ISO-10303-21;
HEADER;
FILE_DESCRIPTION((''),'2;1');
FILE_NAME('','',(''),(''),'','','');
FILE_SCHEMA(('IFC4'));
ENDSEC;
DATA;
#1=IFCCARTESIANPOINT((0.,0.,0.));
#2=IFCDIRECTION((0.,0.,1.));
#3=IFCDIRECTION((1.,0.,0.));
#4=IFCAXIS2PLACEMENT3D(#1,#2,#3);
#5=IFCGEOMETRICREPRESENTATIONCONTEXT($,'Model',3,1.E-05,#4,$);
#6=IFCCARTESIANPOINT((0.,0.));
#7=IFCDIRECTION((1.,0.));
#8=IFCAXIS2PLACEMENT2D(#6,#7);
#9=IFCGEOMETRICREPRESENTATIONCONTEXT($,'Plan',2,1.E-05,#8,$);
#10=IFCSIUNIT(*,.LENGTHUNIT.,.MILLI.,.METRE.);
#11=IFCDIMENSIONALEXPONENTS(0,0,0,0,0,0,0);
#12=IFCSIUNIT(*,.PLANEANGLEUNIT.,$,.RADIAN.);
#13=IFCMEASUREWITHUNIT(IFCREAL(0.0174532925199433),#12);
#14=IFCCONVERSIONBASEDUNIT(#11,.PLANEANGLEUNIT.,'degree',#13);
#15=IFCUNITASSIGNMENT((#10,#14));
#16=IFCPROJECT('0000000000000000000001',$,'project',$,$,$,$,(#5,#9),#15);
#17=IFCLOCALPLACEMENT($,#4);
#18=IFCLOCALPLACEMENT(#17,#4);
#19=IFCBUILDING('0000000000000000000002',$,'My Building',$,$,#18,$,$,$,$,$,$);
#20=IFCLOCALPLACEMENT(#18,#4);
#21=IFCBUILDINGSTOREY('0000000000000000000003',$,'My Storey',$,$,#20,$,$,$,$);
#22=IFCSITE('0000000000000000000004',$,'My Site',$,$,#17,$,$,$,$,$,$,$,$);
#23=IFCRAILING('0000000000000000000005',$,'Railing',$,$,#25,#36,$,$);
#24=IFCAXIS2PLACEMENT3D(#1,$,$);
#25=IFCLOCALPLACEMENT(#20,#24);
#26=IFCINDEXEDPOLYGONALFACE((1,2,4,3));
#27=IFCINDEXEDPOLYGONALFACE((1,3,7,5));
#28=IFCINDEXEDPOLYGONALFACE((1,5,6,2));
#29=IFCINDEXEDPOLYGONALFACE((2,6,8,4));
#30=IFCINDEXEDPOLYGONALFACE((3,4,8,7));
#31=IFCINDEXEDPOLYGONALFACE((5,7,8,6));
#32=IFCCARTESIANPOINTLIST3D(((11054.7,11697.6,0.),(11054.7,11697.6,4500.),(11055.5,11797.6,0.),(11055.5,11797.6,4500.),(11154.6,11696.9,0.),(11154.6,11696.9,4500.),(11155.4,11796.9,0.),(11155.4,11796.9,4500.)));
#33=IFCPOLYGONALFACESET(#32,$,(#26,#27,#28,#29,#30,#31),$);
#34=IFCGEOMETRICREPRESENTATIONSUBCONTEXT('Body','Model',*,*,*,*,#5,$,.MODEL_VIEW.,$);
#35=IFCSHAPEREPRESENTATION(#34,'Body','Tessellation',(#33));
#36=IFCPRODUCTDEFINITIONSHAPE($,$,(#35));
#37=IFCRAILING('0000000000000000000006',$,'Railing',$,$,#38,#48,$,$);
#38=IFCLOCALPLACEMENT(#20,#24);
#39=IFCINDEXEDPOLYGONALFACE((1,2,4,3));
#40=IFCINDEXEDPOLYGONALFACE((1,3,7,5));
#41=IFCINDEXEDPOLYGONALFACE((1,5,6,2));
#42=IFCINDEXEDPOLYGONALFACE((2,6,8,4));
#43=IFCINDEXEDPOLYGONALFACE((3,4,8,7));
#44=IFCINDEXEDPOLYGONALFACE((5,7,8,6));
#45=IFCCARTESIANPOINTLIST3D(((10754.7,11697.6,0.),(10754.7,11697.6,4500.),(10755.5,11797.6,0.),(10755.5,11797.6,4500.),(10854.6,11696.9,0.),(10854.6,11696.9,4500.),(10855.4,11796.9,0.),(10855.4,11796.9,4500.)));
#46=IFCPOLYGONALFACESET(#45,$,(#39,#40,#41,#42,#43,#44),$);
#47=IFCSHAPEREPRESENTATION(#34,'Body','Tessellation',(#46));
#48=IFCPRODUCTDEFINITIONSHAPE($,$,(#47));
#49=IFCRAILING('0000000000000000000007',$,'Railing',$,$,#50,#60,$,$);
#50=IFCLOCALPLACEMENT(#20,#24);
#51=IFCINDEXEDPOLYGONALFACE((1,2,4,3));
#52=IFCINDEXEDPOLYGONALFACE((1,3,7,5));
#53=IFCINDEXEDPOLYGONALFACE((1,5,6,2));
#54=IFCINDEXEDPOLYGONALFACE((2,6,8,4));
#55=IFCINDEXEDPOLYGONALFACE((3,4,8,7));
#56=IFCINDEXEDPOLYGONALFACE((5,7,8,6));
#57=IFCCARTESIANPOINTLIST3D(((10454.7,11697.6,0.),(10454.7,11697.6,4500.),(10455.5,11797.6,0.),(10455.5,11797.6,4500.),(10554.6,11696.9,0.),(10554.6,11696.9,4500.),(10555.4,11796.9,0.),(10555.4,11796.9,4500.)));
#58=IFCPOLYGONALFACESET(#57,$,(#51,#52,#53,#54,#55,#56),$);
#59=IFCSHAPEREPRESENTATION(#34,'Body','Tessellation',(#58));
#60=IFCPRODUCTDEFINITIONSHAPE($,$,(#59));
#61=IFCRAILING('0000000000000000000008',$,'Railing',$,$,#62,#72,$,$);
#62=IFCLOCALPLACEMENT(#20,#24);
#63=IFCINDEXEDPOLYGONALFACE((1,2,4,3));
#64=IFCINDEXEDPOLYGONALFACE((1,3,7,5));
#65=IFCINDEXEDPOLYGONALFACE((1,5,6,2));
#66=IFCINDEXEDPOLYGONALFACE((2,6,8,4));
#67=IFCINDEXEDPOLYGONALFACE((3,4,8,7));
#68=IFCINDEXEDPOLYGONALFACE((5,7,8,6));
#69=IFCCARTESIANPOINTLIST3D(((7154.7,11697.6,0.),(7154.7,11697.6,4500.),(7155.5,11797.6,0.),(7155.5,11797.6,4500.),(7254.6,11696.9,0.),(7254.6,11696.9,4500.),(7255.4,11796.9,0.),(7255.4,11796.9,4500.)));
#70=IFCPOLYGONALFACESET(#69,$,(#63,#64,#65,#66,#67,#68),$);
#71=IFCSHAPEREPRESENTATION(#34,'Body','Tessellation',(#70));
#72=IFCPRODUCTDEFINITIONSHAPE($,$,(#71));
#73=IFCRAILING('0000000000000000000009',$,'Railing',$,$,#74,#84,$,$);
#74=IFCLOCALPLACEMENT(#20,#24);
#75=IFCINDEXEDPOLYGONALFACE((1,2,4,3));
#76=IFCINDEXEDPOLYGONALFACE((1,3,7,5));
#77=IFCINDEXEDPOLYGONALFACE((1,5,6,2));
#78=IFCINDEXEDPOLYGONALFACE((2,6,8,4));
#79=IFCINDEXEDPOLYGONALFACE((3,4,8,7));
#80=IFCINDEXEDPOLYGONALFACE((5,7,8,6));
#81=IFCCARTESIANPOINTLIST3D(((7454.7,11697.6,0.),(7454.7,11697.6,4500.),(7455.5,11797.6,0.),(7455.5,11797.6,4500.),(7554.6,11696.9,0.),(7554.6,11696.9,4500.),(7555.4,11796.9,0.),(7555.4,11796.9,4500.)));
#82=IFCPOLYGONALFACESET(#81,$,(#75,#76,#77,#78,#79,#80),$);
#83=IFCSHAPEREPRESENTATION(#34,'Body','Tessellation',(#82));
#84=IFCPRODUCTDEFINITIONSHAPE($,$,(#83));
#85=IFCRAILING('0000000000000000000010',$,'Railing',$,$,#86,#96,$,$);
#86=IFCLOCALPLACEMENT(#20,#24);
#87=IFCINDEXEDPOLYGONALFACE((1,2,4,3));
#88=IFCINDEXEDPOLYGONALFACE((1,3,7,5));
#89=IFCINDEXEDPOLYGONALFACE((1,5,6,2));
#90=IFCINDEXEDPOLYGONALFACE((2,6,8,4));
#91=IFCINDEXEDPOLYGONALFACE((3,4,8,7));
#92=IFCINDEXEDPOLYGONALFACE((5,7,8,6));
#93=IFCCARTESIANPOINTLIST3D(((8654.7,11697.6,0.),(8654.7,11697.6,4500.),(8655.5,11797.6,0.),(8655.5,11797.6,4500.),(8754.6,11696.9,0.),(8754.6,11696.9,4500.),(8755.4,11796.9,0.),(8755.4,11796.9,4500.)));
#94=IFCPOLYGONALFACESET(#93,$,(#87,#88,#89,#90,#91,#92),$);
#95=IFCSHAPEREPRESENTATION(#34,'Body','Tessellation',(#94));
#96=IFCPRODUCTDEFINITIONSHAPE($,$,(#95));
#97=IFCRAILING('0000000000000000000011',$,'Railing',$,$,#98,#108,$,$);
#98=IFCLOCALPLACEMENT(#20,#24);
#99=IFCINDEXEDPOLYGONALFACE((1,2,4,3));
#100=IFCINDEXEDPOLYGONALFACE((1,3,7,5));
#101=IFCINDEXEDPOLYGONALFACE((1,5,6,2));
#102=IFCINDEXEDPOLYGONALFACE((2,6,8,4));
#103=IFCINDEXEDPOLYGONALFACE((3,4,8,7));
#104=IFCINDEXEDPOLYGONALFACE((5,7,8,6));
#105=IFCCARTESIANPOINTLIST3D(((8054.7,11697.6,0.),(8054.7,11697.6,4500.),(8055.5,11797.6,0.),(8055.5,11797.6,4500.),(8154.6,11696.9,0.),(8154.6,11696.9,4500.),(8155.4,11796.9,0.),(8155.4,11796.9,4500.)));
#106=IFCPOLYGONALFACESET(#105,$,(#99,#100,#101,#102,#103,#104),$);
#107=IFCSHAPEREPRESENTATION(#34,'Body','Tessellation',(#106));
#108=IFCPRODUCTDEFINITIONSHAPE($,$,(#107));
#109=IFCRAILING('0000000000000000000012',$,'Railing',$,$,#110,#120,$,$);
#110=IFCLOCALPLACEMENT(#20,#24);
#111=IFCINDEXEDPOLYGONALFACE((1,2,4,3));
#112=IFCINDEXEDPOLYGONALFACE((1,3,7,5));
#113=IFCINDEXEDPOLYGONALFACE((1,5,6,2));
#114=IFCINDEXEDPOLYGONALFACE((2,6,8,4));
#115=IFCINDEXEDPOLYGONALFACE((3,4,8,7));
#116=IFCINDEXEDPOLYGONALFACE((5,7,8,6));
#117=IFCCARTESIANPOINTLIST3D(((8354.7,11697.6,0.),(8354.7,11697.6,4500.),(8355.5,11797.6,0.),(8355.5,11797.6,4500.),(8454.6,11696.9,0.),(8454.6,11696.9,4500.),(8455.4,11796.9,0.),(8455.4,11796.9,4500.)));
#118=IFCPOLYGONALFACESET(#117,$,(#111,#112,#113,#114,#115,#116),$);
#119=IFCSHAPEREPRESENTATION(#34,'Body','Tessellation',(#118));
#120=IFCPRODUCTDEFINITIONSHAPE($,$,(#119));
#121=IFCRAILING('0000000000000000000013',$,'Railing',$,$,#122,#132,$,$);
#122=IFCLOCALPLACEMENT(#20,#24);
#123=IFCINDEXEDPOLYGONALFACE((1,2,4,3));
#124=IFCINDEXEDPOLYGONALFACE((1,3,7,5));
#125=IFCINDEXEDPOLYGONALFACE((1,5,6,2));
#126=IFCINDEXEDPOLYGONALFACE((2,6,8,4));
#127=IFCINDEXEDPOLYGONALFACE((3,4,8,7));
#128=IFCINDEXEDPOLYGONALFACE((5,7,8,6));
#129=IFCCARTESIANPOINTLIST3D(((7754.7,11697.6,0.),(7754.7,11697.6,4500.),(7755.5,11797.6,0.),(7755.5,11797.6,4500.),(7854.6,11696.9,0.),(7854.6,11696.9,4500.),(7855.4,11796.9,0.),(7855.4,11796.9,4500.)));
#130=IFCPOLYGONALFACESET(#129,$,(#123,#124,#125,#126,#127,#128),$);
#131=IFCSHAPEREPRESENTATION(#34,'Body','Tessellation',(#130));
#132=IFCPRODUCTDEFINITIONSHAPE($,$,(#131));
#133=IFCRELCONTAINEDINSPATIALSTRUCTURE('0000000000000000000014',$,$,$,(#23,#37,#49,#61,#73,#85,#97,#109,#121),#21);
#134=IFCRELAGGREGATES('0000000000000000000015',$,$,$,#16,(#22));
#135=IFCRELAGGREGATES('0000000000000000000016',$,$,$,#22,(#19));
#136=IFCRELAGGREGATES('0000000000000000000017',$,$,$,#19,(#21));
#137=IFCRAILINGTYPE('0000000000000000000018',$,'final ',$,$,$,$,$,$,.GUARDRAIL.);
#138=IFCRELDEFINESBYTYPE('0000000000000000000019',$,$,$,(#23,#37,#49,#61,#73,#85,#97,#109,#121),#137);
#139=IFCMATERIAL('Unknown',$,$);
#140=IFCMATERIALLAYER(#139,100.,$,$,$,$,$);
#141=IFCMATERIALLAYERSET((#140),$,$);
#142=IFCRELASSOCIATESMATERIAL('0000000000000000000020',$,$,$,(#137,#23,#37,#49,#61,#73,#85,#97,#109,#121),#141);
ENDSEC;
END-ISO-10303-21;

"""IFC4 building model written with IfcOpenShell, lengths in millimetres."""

from ifc_helpers import new_model, entity, si_unit, converted_unit, frame, origin_with_axes, origin_2d_with_axis, place, context, subcontext, project, spatial, line, indexed_curve, outline, extrude, material, layer, layer_set, layer_usage, type_object, element, save


model = new_model("IFC4")

# Units and contexts
model_context = context("Model", 3, precision=1e-05, world=origin_with_axes())
plan_context = context("Plan", 2, precision=1e-05, world=origin_2d_with_axis())
body_context = subcontext(model_context, "Body", "Model", "MODEL_VIEW")
ifc_project = project(units=[si_unit("LENGTHUNIT", "METRE", prefix="MILLI"), converted_unit("PLANEANGLEUNIT", "degree", entity("IfcReal", 0.0174532925199433), si_unit("PLANEANGLEUNIT", "RADIAN"), dimensions=[0, 0, 0, 0, 0, 0, 0])], contexts=[model_context, plan_context])

# Site, building, storey
site_placement = place(None, origin_with_axes())
site = spatial("IfcSite", under=ifc_project, at=site_placement, Name="My Site")
building_placement = place(site_placement, origin_with_axes())
building = spatial("IfcBuilding", under=site, at=building_placement, Name="My Building")
storey_placement = place(building_placement, origin_with_axes())
storey = spatial("IfcBuildingStorey", under=building, at=storey_placement, Name="My Storey")

# Shared definitions
ifc_material = material(Name="Unknown")

# Railings
ifc_layer_1 = layer(ifc_material, 100.0)
ifc_layer_set_1 = layer_set([ifc_layer_1])
railing_type = type_object("IfcRailingType", Name="final ", PredefinedType="GUARDRAIL", material=ifc_layer_set_1)
ifc_layer_usage_1 = layer_usage(ifc_layer_set_1, "AXIS2", "POSITIVE", 0.0)
railing_1_placement = place(storey_placement, frame((11155.4, 11796.9, 0.0), z_axis=(0.0, 0.0, 1.0), x_axis=(-0.99997, 0.007689, 0.0)))
element("IfcRailing", 1, at=railing_1_placement, inside=storey, type_object=railing_type, material=ifc_layer_usage_1, Name="Railing", context=body_context, shape_type="SweptSolid", body=[
    extrude(outline(indexed_curve([(0.0, 0.0), (0.0, 100.0), (99.8, 100.0), (99.8, 0.0)], segments=[line(1, 2, 3, 4, 1)])), origin_with_axes(), (0.0, 0.0, 1.0), 4500.0),
])
ifc_layer_usage_2 = layer_usage(ifc_layer_set_1, "AXIS2", "POSITIVE", 0.0)
railing_2_placement = place(storey_placement, frame((10855.4, 11796.9, 0.0), z_axis=(0.0, 0.0, 1.0), x_axis=(-0.99997, 0.007689, 0.0)))
element("IfcRailing", 2, at=railing_2_placement, inside=storey, type_object=railing_type, material=ifc_layer_usage_2, Name="Railing", context=body_context, shape_type="SweptSolid", body=[
    extrude(outline(indexed_curve([(0.0, 0.0), (0.0, 100.0), (99.8, 100.0), (99.8, 0.0)], segments=[line(1, 2, 3, 4, 1)])), origin_with_axes(), (0.0, 0.0, 1.0), 4500.0),
])
ifc_layer_usage_3 = layer_usage(ifc_layer_set_1, "AXIS2", "POSITIVE", 0.0)
railing_3_placement = place(storey_placement, frame((10555.4, 11796.9, 0.0), z_axis=(0.0, 0.0, 1.0), x_axis=(-0.99997, 0.007689, 0.0)))
element("IfcRailing", 3, at=railing_3_placement, inside=storey, type_object=railing_type, material=ifc_layer_usage_3, Name="Railing", context=body_context, shape_type="SweptSolid", body=[
    extrude(outline(indexed_curve([(0.0, 0.0), (0.0, 100.0), (99.8, 100.0), (99.8, 0.0)], segments=[line(1, 2, 3, 4, 1)])), origin_with_axes(), (0.0, 0.0, 1.0), 4500.0),
])
ifc_layer_usage_4 = layer_usage(ifc_layer_set_1, "AXIS2", "POSITIVE", 0.0)
railing_4_placement = place(storey_placement, frame((7255.4, 11796.9, 0.0), z_axis=(0.0, 0.0, 1.0), x_axis=(-0.99997, 0.007689, 0.0)))
element("IfcRailing", 4, at=railing_4_placement, inside=storey, type_object=railing_type, material=ifc_layer_usage_4, Name="Railing", context=body_context, shape_type="SweptSolid", body=[
    extrude(outline(indexed_curve([(0.0, 0.0), (0.0, 100.0), (99.8, 100.0), (99.8, 0.0)], segments=[line(1, 2, 3, 4, 1)])), origin_with_axes(), (0.0, 0.0, 1.0), 4500.0),
])
ifc_layer_usage_5 = layer_usage(ifc_layer_set_1, "AXIS2", "POSITIVE", 0.0)
railing_5_placement = place(storey_placement, frame((7555.4, 11796.9, 0.0), z_axis=(0.0, 0.0, 1.0), x_axis=(-0.99997, 0.007689, 0.0)))
element("IfcRailing", 5, at=railing_5_placement, inside=storey, type_object=railing_type, material=ifc_layer_usage_5, Name="Railing", context=body_context, shape_type="SweptSolid", body=[
    extrude(outline(indexed_curve([(0.0, 0.0), (0.0, 100.0), (99.8, 100.0), (99.8, 0.0)], segments=[line(1, 2, 3, 4, 1)])), origin_with_axes(), (0.0, 0.0, 1.0), 4500.0),
])
ifc_layer_usage_6 = layer_usage(ifc_layer_set_1, "AXIS2", "POSITIVE", 0.0)
railing_6_placement = place(storey_placement, frame((8755.4, 11796.9, 0.0), z_axis=(0.0, 0.0, 1.0), x_axis=(-0.99997, 0.007689, 0.0)))
element("IfcRailing", 6, at=railing_6_placement, inside=storey, type_object=railing_type, material=ifc_layer_usage_6, Name="Railing", context=body_context, shape_type="SweptSolid", body=[
    extrude(outline(indexed_curve([(0.0, 0.0), (0.0, 100.0), (99.8, 100.0), (99.8, 0.0)], segments=[line(1, 2, 3, 4, 1)])), origin_with_axes(), (0.0, 0.0, 1.0), 4500.0),
])
ifc_layer_usage_7 = layer_usage(ifc_layer_set_1, "AXIS2", "POSITIVE", 0.0)
railing_7_placement = place(storey_placement, frame((8155.4, 11796.9, 0.0), z_axis=(0.0, 0.0, 1.0), x_axis=(-0.99997, 0.007689, 0.0)))
element("IfcRailing", 7, at=railing_7_placement, inside=storey, type_object=railing_type, material=ifc_layer_usage_7, Name="Railing", context=body_context, shape_type="SweptSolid", body=[
    extrude(outline(indexed_curve([(0.0, 0.0), (0.0, 100.0), (99.8, 100.0), (99.8, 0.0)], segments=[line(1, 2, 3, 4, 1)])), origin_with_axes(), (0.0, 0.0, 1.0), 4500.0),
])
ifc_layer_usage_8 = layer_usage(ifc_layer_set_1, "AXIS2", "POSITIVE", 0.0)
railing_8_placement = place(storey_placement, frame((8455.4, 11796.9, 0.0), z_axis=(0.0, 0.0, 1.0), x_axis=(-0.99997, 0.007689, 0.0)))
element("IfcRailing", 8, at=railing_8_placement, inside=storey, type_object=railing_type, material=ifc_layer_usage_8, Name="Railing", context=body_context, shape_type="SweptSolid", body=[
    extrude(outline(indexed_curve([(0.0, 0.0), (0.0, 100.0), (99.8, 100.0), (99.8, 0.0)], segments=[line(1, 2, 3, 4, 1)])), origin_with_axes(), (0.0, 0.0, 1.0), 4500.0),
])
ifc_layer_usage_9 = layer_usage(ifc_layer_set_1, "AXIS2", "POSITIVE", 0.0)
railing_9_placement = place(storey_placement, frame((7855.4, 11796.9, 0.0), z_axis=(0.0, 0.0, 1.0), x_axis=(-0.99997, 0.007689, 0.0)))
element("IfcRailing", 9, at=railing_9_placement, inside=storey, type_object=railing_type, material=ifc_layer_usage_9, Name="Railing", context=body_context, shape_type="SweptSolid", body=[
    extrude(outline(indexed_curve([(0.0, 0.0), (0.0, 100.0), (99.8, 100.0), (99.8, 0.0)], segments=[line(1, 2, 3, 4, 1)])), origin_with_axes(), (0.0, 0.0, 1.0), 4500.0),
])

save(model, "model.ifc")
